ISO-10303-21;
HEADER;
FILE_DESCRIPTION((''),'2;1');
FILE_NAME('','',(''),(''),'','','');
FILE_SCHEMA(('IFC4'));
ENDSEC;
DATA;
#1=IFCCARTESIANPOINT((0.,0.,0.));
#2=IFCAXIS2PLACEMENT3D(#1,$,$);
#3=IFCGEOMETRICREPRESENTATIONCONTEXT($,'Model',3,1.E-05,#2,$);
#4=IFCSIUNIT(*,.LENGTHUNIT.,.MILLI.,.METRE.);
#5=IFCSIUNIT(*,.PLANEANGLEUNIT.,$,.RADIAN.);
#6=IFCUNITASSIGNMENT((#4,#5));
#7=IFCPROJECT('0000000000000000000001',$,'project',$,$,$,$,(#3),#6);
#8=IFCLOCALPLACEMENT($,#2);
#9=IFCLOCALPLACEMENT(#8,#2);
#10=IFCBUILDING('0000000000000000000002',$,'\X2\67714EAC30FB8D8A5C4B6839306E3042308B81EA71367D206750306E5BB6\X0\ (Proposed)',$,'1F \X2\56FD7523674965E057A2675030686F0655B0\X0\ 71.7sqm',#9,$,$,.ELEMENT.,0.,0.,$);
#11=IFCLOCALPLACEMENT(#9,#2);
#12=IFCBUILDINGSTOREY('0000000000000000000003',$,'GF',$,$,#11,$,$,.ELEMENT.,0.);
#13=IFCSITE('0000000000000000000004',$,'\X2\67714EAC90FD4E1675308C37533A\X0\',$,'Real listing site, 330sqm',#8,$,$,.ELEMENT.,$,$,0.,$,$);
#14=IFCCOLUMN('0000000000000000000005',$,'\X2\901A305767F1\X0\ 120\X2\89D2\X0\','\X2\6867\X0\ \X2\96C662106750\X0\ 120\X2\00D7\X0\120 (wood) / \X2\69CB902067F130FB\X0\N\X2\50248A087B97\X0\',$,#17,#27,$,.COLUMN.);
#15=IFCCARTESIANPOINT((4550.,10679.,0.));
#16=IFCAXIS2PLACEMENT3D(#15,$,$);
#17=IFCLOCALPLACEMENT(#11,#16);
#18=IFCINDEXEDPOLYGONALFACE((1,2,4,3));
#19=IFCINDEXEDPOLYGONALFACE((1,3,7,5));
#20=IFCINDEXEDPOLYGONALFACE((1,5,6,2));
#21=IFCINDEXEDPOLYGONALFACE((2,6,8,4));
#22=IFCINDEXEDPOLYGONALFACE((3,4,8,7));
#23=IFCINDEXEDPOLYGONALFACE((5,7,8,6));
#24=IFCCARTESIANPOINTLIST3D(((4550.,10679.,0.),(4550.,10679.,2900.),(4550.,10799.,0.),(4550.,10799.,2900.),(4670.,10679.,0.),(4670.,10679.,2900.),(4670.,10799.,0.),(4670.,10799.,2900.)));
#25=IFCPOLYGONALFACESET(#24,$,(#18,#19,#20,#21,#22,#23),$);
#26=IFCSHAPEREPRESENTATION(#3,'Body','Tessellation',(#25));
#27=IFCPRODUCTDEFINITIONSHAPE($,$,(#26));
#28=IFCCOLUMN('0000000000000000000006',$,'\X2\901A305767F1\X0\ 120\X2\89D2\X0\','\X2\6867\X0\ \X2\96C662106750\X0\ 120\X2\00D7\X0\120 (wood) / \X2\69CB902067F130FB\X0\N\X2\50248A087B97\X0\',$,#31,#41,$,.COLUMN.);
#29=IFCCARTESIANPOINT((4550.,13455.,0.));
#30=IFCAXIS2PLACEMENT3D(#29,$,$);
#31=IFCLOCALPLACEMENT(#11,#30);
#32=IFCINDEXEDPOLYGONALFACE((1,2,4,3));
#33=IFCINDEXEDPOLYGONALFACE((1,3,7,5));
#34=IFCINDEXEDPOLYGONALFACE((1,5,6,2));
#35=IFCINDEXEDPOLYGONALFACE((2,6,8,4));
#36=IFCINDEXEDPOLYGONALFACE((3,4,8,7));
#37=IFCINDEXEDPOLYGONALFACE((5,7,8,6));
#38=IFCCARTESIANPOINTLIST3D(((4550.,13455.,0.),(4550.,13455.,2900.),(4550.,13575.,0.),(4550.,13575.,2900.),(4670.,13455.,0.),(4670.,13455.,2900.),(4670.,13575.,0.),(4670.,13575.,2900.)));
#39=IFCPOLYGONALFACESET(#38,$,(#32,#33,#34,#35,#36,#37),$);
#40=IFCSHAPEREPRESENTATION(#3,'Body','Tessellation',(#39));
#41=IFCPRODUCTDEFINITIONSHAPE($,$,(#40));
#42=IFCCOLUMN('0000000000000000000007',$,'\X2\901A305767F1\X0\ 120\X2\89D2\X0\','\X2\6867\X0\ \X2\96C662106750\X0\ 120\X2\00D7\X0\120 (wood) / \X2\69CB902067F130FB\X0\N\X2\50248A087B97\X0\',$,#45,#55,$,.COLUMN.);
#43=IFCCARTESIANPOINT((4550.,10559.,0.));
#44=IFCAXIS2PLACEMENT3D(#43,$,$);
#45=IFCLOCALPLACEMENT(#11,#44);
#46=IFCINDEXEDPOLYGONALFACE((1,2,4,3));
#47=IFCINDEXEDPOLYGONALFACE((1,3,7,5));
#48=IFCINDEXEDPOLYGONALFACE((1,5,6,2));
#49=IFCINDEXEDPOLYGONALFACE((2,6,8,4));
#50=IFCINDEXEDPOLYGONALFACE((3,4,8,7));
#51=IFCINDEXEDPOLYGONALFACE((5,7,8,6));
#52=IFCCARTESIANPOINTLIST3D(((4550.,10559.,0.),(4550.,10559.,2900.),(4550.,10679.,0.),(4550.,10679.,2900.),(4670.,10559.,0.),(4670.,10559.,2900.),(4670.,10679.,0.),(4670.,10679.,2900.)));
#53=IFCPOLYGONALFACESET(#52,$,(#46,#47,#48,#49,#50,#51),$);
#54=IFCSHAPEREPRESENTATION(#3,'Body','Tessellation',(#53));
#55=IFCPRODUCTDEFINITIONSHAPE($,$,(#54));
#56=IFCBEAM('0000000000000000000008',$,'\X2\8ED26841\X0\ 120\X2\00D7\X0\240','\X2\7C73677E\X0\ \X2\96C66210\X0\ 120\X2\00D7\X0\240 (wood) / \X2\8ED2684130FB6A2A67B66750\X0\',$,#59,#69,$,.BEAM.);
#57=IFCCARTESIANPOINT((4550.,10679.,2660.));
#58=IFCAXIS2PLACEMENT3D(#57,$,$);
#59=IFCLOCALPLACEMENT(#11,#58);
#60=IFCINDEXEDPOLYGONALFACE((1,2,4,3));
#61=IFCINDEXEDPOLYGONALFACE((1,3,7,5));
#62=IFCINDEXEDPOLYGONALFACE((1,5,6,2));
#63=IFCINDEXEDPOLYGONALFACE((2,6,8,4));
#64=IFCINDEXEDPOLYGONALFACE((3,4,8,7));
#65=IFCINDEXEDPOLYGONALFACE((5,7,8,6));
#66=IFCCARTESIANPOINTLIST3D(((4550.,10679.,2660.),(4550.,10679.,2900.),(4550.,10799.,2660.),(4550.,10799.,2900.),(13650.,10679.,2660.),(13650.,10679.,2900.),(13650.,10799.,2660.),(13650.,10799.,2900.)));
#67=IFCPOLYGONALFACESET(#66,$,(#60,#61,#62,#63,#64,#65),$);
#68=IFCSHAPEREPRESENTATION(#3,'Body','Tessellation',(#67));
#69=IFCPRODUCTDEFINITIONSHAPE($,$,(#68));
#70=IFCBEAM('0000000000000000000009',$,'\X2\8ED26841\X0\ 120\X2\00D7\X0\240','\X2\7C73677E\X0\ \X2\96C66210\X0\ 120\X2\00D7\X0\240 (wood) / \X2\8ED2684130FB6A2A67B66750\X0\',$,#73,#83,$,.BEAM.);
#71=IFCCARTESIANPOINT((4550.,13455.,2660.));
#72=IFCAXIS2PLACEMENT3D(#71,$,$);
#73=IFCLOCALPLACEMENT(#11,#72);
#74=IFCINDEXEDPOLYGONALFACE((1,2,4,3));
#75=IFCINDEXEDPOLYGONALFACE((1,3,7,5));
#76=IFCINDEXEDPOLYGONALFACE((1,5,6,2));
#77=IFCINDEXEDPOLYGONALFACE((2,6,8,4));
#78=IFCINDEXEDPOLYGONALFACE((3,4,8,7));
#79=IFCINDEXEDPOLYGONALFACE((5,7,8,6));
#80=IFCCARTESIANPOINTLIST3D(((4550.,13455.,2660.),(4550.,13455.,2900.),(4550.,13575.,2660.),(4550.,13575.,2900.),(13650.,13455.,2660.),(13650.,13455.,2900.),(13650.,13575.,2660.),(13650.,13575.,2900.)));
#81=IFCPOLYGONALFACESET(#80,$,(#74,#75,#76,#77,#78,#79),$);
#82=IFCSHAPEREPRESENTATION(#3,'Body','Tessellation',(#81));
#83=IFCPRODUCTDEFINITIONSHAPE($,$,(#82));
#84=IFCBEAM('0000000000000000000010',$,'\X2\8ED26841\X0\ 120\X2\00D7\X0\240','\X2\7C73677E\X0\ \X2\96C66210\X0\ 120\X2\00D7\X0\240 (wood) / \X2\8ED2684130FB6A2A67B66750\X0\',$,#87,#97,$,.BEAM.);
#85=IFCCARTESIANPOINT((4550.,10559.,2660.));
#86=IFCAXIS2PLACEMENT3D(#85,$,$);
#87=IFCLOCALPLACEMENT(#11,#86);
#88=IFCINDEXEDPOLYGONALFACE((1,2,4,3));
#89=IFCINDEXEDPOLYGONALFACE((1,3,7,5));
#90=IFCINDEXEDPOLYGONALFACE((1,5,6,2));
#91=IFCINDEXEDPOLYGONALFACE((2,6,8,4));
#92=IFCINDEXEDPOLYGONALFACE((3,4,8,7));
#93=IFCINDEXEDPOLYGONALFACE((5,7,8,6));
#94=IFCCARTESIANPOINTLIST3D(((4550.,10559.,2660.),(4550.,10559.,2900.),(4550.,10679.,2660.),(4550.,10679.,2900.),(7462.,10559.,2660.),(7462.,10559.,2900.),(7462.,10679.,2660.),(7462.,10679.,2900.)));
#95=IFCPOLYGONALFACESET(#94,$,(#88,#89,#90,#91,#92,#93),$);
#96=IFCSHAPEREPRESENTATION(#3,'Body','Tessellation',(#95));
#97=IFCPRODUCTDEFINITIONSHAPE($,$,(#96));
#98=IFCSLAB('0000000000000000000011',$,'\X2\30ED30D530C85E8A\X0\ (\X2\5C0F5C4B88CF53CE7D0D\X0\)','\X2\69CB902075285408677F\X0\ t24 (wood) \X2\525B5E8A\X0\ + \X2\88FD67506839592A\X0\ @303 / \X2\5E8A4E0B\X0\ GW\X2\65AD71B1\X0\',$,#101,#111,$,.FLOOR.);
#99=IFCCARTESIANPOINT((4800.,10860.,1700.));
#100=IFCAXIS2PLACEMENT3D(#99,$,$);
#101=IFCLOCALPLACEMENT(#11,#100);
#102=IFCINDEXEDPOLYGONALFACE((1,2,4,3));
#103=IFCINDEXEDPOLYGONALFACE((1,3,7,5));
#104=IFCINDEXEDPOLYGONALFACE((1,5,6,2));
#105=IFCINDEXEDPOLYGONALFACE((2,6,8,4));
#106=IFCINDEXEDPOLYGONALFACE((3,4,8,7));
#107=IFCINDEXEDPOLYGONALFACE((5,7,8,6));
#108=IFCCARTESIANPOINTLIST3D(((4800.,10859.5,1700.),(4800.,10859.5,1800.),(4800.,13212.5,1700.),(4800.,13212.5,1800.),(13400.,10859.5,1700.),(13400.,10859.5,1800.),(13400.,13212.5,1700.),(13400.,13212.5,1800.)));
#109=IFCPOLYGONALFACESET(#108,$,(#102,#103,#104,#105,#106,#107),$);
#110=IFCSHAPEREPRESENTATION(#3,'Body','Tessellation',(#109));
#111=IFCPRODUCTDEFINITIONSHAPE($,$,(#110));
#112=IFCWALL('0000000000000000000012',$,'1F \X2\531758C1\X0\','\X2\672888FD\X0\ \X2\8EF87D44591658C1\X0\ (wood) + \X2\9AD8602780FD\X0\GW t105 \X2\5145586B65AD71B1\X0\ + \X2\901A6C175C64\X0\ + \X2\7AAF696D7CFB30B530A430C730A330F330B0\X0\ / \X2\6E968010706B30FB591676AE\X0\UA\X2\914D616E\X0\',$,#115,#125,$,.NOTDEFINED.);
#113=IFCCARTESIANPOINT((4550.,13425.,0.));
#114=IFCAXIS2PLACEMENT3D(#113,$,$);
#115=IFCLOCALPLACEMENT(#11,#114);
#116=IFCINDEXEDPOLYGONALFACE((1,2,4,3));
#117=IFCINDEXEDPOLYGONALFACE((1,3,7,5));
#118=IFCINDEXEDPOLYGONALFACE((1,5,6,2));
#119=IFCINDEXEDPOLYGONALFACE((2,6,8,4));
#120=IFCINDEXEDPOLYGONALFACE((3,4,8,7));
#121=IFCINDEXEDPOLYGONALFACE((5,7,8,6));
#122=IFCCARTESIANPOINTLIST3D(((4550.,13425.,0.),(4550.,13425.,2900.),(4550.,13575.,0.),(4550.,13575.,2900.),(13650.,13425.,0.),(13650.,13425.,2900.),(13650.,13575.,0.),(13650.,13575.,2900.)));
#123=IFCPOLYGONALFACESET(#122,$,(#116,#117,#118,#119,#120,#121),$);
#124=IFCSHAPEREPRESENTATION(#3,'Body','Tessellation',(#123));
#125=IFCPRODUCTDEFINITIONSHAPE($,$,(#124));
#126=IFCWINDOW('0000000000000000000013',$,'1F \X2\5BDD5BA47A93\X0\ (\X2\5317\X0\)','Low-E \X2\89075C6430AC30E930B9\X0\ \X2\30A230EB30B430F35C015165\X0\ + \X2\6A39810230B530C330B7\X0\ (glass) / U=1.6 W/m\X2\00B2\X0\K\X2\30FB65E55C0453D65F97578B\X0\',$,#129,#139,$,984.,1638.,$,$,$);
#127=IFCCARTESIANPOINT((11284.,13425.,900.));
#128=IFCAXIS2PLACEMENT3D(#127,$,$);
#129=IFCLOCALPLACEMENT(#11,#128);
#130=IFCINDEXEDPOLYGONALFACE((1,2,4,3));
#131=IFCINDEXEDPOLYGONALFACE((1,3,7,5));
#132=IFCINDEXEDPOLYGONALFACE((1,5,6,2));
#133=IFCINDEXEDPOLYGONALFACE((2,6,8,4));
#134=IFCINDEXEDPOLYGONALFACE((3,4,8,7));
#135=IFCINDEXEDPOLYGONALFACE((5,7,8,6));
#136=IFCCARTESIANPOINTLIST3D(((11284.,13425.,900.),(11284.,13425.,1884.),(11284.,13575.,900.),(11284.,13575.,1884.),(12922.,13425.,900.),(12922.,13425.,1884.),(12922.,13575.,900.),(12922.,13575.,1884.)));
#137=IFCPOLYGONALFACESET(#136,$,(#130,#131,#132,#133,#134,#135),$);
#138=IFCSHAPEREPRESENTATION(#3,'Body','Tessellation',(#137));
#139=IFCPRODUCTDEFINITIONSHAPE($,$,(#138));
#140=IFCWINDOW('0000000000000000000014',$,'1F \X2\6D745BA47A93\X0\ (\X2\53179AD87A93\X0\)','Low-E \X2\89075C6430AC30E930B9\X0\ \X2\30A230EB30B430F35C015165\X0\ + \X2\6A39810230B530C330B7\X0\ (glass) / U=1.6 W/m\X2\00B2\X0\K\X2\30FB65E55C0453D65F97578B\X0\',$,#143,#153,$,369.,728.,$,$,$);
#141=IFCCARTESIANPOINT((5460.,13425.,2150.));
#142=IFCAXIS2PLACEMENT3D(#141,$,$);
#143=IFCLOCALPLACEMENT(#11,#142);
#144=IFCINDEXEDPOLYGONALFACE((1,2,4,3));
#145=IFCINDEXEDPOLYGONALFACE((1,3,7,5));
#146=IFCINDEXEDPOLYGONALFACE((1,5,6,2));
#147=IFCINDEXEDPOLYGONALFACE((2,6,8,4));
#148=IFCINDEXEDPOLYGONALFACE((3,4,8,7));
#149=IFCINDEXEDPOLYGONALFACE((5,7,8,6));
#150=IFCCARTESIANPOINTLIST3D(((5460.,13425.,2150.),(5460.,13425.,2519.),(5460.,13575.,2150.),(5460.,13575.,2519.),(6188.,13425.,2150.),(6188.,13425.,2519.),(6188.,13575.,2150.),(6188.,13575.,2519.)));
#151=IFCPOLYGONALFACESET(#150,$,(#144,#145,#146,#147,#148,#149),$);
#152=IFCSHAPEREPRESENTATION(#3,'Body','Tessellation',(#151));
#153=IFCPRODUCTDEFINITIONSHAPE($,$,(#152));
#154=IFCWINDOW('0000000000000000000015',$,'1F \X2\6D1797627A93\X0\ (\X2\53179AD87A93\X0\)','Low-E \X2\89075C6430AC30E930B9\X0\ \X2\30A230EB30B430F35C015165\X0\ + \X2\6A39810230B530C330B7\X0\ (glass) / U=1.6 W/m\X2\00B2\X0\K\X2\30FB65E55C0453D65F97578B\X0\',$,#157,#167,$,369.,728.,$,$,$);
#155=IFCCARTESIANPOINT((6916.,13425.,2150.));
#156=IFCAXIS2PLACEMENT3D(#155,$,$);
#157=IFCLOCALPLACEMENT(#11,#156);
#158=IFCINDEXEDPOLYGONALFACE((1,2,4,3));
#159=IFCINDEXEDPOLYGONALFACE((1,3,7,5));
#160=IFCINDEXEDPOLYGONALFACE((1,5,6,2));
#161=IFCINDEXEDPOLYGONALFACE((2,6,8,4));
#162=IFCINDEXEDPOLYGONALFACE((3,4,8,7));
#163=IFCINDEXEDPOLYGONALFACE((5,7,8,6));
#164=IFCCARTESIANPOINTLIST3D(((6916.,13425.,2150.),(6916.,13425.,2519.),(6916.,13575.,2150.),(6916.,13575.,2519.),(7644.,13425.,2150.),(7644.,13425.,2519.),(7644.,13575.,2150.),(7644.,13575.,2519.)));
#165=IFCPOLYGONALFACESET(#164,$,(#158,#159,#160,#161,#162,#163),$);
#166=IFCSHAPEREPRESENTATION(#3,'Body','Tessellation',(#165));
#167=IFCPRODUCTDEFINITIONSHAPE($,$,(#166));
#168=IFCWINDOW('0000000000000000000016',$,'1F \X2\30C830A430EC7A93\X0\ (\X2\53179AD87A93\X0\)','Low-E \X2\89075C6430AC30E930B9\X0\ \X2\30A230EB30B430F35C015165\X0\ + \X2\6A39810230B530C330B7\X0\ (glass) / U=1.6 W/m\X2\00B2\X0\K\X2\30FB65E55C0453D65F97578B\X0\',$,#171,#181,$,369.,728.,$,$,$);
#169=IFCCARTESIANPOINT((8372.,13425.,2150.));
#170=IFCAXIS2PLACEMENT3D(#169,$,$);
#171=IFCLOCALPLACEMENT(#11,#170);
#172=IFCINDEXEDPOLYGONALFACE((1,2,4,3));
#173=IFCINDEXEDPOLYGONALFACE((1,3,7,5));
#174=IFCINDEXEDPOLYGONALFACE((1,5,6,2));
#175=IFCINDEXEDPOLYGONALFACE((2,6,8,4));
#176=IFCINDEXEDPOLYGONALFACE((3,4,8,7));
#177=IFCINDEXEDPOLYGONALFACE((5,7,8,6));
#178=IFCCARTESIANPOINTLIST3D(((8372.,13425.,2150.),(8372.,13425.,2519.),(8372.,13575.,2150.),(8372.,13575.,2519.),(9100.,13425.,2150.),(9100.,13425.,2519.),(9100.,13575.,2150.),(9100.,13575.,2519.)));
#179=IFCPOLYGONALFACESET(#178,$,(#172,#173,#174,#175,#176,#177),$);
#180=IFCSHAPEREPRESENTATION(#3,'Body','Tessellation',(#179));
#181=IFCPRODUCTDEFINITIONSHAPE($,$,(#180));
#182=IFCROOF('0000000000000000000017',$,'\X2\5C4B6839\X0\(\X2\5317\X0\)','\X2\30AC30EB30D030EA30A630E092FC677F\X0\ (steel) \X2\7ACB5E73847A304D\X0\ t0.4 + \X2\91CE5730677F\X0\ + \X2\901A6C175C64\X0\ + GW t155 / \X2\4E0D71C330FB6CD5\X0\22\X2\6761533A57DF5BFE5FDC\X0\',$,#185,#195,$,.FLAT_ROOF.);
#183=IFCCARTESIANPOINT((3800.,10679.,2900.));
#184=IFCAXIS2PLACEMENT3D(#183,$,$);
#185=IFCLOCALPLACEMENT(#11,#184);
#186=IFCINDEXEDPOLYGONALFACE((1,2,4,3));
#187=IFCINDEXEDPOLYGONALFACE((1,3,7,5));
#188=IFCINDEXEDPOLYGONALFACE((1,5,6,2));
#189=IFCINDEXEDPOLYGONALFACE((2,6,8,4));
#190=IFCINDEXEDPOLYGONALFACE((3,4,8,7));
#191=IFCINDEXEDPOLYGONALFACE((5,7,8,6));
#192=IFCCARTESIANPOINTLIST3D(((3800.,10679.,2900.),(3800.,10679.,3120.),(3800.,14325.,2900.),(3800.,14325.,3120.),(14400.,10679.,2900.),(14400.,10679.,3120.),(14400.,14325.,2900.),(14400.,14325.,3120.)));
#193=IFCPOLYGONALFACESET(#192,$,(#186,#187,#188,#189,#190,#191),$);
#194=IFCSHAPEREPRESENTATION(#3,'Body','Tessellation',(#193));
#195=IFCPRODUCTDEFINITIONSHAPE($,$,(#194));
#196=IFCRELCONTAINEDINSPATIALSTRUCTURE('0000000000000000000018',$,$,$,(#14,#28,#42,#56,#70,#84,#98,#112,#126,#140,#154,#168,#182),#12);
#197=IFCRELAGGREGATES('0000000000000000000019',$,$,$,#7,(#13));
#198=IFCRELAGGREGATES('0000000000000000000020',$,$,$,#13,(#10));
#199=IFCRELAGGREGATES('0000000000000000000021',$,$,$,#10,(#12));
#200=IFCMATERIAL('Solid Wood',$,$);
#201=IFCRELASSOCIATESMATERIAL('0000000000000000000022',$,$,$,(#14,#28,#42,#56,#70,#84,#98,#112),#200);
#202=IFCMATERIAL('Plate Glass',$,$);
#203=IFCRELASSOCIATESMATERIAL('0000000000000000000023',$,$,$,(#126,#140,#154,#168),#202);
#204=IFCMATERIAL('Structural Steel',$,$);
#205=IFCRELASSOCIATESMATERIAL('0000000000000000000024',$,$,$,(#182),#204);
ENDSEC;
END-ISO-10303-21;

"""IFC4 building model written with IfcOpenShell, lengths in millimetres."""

from ifc_helpers import new_model, si_unit, frame, frame_2d, origin, place, context, project, spatial, rectangle, extrude, material, element, fill, save


model = new_model("IFC4")

# Units and contexts
model_context = context("Model", 3, precision=1e-05, world=origin())
ifc_project = project(units=[si_unit("LENGTHUNIT", "METRE", prefix="MILLI"), si_unit("PLANEANGLEUNIT", "RADIAN")], contexts=[model_context])

# Site, building, storey
site_placement = place(None, origin())
site = spatial("IfcSite", under=ifc_project, at=site_placement, Name="東京都世田谷区", ObjectType="Real listing site, 330sqm", CompositionType="ELEMENT", RefElevation=0.0)
building_placement = place(site_placement, origin())
building = spatial("IfcBuilding", under=site, at=building_placement, Name="東京・越屋根のある自然素材の家 (Proposed)", ObjectType="1F 国産杉无垢材と漆喰 71.7sqm", CompositionType="ELEMENT", ElevationOfRefHeight=0.0, ElevationOfTerrain=0.0)
storey_placement = place(building_placement, origin())
storey = spatial("IfcBuildingStorey", under=building, at=storey_placement, Name="GF", CompositionType="ELEMENT", Elevation=0.0)

# Columns
ifc_material_1 = material(Name="Solid Wood")
column_1_placement = place(storey_placement, frame((4550.0, 10679.0, 0.0)))
element("IfcColumn", 1, at=column_1_placement, inside=storey, material=ifc_material_1, Name="通し柱 120角", Description="桧 集成材 120×120 (wood) / 構造柱・N値計算", PredefinedType="COLUMN", context=model_context, shape_type="SweptSolid", body=[
    extrude(rectangle(XDim=120.0, YDim=120.0, at=frame_2d((60.0, 60.0))), frame((4550.0, 10679.0, 0.0)), (0.0, 0.0, 1.0), 2900.0),
])
column_2_placement = place(storey_placement, frame((4550.0, 13455.0, 0.0)))
element("IfcColumn", 2, at=column_2_placement, inside=storey, material=ifc_material_1, Name="通し柱 120角", Description="桧 集成材 120×120 (wood) / 構造柱・N値計算", PredefinedType="COLUMN", context=model_context, shape_type="SweptSolid", body=[
    extrude(rectangle(XDim=120.0, YDim=120.0, at=frame_2d((60.0, 60.0))), frame((4550.0, 13455.0, 0.0)), (0.0, 0.0, 1.0), 2900.0),
])
column_3_placement = place(storey_placement, frame((4550.0, 10559.0, 0.0)))
element("IfcColumn", 3, at=column_3_placement, inside=storey, material=ifc_material_1, Name="通し柱 120角", Description="桧 集成材 120×120 (wood) / 構造柱・N値計算", PredefinedType="COLUMN", context=model_context, shape_type="SweptSolid", body=[
    extrude(rectangle(XDim=120.0, YDim=120.0, at=frame_2d((60.0, 60.0))), frame((4550.0, 10559.0, 0.0)), (0.0, 0.0, 1.0), 2900.0),
])

# Beams
beam_1_placement = place(storey_placement, frame((4550.0, 10679.0, 2660.0)))
element("IfcBeam", 4, at=beam_1_placement, inside=storey, material=ifc_material_1, Name="軒桁 120×240", Description="米松 集成 120×240 (wood) / 軒桁・横架材", PredefinedType="BEAM", context=model_context, shape_type="SweptSolid", body=[
    extrude(rectangle(XDim=9100.0, YDim=120.0, at=frame_2d((4550.0, 60.0))), frame((4550.0, 10679.0, 2660.0)), (0.0, 0.0, 1.0), 240.0),
])
beam_2_placement = place(storey_placement, frame((4550.0, 13455.0, 2660.0)))
element("IfcBeam", 5, at=beam_2_placement, inside=storey, material=ifc_material_1, Name="軒桁 120×240", Description="米松 集成 120×240 (wood) / 軒桁・横架材", PredefinedType="BEAM", context=model_context, shape_type="SweptSolid", body=[
    extrude(rectangle(XDim=9100.0, YDim=120.0, at=frame_2d((4550.0, 60.0))), frame((4550.0, 13455.0, 2660.0)), (0.0, 0.0, 1.0), 240.0),
])
beam_3_placement = place(storey_placement, frame((4550.0, 10559.0, 2660.0)))
element("IfcBeam", 6, at=beam_3_placement, inside=storey, material=ifc_material_1, Name="軒桁 120×240", Description="米松 集成 120×240 (wood) / 軒桁・横架材", PredefinedType="BEAM", context=model_context, shape_type="SweptSolid", body=[
    extrude(rectangle(XDim=2912.0, YDim=120.0, at=frame_2d((1456.0, 60.0))), frame((4550.0, 10559.0, 2660.0)), (0.0, 0.0, 1.0), 240.0),
])

# Slab
slab_1_placement = place(storey_placement, frame((4800.0, 10860.0, 1700.0)))
element("IfcSlab", 7, at=slab_1_placement, inside=storey, material=ifc_material_1, Name="ロフト床 (小屋裏収納)", Description="構造用合板 t24 (wood) 剛床 + 製材根太 @303 / 床下 GW断熱", PredefinedType="FLOOR", context=model_context, shape_type="SweptSolid", body=[
    extrude(rectangle(XDim=8600.0, YDim=2353.0, at=frame_2d((4300.0, 1176.0))), frame((4800.0, 10860.0, 1700.0)), (0.0, 0.0, 1.0), 100.0),
])

# Wall, openings, windows
wall_1_placement = place(storey_placement, frame((4550.0, 13425.0, 0.0)))
wall_1 = element("IfcWall", 8, at=wall_1_placement, inside=storey, material=ifc_material_1, Name="1F 北壁", Description="木製 軸組外壁 (wood) + 高性能GW t105 充填断熱 + 通気層 + 窯業系サイディング / 準耐火・外皮UA配慮", PredefinedType="NOTDEFINED", context=model_context, shape_type="SweptSolid", body=[
    extrude(rectangle(XDim=9100.0, YDim=150.0, at=frame_2d((4550.0, 75.0))), frame((4550.0, 13425.0, 0.0)), (0.0, 0.0, 1.0), 2900.0),
])
opening_1_placement = place(storey_placement, frame((11284.0, 13425.0, 900.0)))
opening_1 = element("IfcOpeningElement", 9, at=opening_1_placement, cuts=wall_1, PredefinedType="NOTDEFINED", context=model_context, shape_type="SweptSolid", body=[
    extrude(rectangle(XDim=1638.0, YDim=150.0, at=frame_2d((819.0, 75.0))), frame((11284.0, 13425.0, 900.0)), (0.0, 0.0, 1.0), 984.0),
])
opening_2_placement = place(storey_placement, frame((5460.0, 13425.0, 2150.0)))
opening_2 = element("IfcOpeningElement", 10, at=opening_2_placement, cuts=wall_1, PredefinedType="NOTDEFINED", context=model_context, shape_type="SweptSolid", body=[
    extrude(rectangle(XDim=728.0, YDim=150.0, at=frame_2d((364.0, 75.0))), frame((5460.0, 13425.0, 2150.0)), (0.0, 0.0, 1.0), 369.0),
])
opening_3_placement = place(storey_placement, frame((6916.0, 13425.0, 2150.0)))
opening_3 = element("IfcOpeningElement", 11, at=opening_3_placement, cuts=wall_1, PredefinedType="NOTDEFINED", context=model_context, shape_type="SweptSolid", body=[
    extrude(rectangle(XDim=728.0, YDim=150.0, at=frame_2d((364.0, 75.0))), frame((6916.0, 13425.0, 2150.0)), (0.0, 0.0, 1.0), 369.0),
])
opening_4_placement = place(storey_placement, frame((8372.0, 13425.0, 2150.0)))
opening_4 = element("IfcOpeningElement", 12, at=opening_4_placement, cuts=wall_1, PredefinedType="NOTDEFINED", context=model_context, shape_type="SweptSolid", body=[
    extrude(rectangle(XDim=728.0, YDim=150.0, at=frame_2d((364.0, 75.0))), frame((8372.0, 13425.0, 2150.0)), (0.0, 0.0, 1.0), 369.0),
])
ifc_material_2 = material(Name="Plate Glass")
window_1_placement = place(storey_placement, frame((11284.0, 13425.0, 900.0)))
window_1 = element("IfcWindow", 13, at=window_1_placement, inside=storey, material=ifc_material_2, Name="1F 寝室窓 (北)", Description="Low-E 複層ガラス アルゴン封入 + 樹脂サッシ (glass) / U=1.6 W/m²K・日射取得型", OverallHeight=984.0, OverallWidth=1638.0, context=model_context, shape_type="SweptSolid", body=[
    extrude(rectangle(XDim=1638.0, YDim=150.0, at=frame_2d((819.0, 75.0))), frame((11284.0, 13425.0, 900.0)), (0.0, 0.0, 1.0), 984.0),
])
fill(opening_1, window_1)
window_2_placement = place(storey_placement, frame((5460.0, 13425.0, 2150.0)))
window_2 = element("IfcWindow", 14, at=window_2_placement, inside=storey, material=ifc_material_2, Name="1F 浴室窓 (北高窓)", Description="Low-E 複層ガラス アルゴン封入 + 樹脂サッシ (glass) / U=1.6 W/m²K・日射取得型", OverallHeight=369.0, OverallWidth=728.0, context=model_context, shape_type="SweptSolid", body=[
    extrude(rectangle(XDim=728.0, YDim=150.0, at=frame_2d((364.0, 75.0))), frame((5460.0, 13425.0, 2150.0)), (0.0, 0.0, 1.0), 369.0),
])
fill(opening_2, window_2)
window_3_placement = place(storey_placement, frame((6916.0, 13425.0, 2150.0)))
window_3 = element("IfcWindow", 15, at=window_3_placement, inside=storey, material=ifc_material_2, Name="1F 洗面窓 (北高窓)", Description="Low-E 複層ガラス アルゴン封入 + 樹脂サッシ (glass) / U=1.6 W/m²K・日射取得型", OverallHeight=369.0, OverallWidth=728.0, context=model_context, shape_type="SweptSolid", body=[
    extrude(rectangle(XDim=728.0, YDim=150.0, at=frame_2d((364.0, 75.0))), frame((6916.0, 13425.0, 2150.0)), (0.0, 0.0, 1.0), 369.0),
])
fill(opening_3, window_3)
window_4_placement = place(storey_placement, frame((8372.0, 13425.0, 2150.0)))
window_4 = element("IfcWindow", 16, at=window_4_placement, inside=storey, material=ifc_material_2, Name="1F トイレ窓 (北高窓)", Description="Low-E 複層ガラス アルゴン封入 + 樹脂サッシ (glass) / U=1.6 W/m²K・日射取得型", OverallHeight=369.0, OverallWidth=728.0, context=model_context, shape_type="SweptSolid", body=[
    extrude(rectangle(XDim=728.0, YDim=150.0, at=frame_2d((364.0, 75.0))), frame((8372.0, 13425.0, 2150.0)), (0.0, 0.0, 1.0), 369.0),
])
fill(opening_4, window_4)

# Roof
ifc_material_3 = material(Name="Structural Steel")
roof_placement = place(storey_placement, frame((3800.0, 10679.0, 2900.0)))
element("IfcRoof", 17, at=roof_placement, inside=storey, material=ifc_material_3, Name="屋根(北)", Description="ガルバリウム鋼板 (steel) 立平葺き t0.4 + 野地板 + 通気層 + GW t155 / 不燃・法22条区域対応", PredefinedType="FLAT_ROOF", context=model_context, shape_type="SweptSolid", body=[
    extrude(rectangle(XDim=10600.0, YDim=3646.0, at=frame_2d((5300.0, 1823.0))), frame((3800.0, 10679.0, 2900.0)), (0.0, 0.0, 1.0), 220.0),
])

save(model, "model.ifc")
